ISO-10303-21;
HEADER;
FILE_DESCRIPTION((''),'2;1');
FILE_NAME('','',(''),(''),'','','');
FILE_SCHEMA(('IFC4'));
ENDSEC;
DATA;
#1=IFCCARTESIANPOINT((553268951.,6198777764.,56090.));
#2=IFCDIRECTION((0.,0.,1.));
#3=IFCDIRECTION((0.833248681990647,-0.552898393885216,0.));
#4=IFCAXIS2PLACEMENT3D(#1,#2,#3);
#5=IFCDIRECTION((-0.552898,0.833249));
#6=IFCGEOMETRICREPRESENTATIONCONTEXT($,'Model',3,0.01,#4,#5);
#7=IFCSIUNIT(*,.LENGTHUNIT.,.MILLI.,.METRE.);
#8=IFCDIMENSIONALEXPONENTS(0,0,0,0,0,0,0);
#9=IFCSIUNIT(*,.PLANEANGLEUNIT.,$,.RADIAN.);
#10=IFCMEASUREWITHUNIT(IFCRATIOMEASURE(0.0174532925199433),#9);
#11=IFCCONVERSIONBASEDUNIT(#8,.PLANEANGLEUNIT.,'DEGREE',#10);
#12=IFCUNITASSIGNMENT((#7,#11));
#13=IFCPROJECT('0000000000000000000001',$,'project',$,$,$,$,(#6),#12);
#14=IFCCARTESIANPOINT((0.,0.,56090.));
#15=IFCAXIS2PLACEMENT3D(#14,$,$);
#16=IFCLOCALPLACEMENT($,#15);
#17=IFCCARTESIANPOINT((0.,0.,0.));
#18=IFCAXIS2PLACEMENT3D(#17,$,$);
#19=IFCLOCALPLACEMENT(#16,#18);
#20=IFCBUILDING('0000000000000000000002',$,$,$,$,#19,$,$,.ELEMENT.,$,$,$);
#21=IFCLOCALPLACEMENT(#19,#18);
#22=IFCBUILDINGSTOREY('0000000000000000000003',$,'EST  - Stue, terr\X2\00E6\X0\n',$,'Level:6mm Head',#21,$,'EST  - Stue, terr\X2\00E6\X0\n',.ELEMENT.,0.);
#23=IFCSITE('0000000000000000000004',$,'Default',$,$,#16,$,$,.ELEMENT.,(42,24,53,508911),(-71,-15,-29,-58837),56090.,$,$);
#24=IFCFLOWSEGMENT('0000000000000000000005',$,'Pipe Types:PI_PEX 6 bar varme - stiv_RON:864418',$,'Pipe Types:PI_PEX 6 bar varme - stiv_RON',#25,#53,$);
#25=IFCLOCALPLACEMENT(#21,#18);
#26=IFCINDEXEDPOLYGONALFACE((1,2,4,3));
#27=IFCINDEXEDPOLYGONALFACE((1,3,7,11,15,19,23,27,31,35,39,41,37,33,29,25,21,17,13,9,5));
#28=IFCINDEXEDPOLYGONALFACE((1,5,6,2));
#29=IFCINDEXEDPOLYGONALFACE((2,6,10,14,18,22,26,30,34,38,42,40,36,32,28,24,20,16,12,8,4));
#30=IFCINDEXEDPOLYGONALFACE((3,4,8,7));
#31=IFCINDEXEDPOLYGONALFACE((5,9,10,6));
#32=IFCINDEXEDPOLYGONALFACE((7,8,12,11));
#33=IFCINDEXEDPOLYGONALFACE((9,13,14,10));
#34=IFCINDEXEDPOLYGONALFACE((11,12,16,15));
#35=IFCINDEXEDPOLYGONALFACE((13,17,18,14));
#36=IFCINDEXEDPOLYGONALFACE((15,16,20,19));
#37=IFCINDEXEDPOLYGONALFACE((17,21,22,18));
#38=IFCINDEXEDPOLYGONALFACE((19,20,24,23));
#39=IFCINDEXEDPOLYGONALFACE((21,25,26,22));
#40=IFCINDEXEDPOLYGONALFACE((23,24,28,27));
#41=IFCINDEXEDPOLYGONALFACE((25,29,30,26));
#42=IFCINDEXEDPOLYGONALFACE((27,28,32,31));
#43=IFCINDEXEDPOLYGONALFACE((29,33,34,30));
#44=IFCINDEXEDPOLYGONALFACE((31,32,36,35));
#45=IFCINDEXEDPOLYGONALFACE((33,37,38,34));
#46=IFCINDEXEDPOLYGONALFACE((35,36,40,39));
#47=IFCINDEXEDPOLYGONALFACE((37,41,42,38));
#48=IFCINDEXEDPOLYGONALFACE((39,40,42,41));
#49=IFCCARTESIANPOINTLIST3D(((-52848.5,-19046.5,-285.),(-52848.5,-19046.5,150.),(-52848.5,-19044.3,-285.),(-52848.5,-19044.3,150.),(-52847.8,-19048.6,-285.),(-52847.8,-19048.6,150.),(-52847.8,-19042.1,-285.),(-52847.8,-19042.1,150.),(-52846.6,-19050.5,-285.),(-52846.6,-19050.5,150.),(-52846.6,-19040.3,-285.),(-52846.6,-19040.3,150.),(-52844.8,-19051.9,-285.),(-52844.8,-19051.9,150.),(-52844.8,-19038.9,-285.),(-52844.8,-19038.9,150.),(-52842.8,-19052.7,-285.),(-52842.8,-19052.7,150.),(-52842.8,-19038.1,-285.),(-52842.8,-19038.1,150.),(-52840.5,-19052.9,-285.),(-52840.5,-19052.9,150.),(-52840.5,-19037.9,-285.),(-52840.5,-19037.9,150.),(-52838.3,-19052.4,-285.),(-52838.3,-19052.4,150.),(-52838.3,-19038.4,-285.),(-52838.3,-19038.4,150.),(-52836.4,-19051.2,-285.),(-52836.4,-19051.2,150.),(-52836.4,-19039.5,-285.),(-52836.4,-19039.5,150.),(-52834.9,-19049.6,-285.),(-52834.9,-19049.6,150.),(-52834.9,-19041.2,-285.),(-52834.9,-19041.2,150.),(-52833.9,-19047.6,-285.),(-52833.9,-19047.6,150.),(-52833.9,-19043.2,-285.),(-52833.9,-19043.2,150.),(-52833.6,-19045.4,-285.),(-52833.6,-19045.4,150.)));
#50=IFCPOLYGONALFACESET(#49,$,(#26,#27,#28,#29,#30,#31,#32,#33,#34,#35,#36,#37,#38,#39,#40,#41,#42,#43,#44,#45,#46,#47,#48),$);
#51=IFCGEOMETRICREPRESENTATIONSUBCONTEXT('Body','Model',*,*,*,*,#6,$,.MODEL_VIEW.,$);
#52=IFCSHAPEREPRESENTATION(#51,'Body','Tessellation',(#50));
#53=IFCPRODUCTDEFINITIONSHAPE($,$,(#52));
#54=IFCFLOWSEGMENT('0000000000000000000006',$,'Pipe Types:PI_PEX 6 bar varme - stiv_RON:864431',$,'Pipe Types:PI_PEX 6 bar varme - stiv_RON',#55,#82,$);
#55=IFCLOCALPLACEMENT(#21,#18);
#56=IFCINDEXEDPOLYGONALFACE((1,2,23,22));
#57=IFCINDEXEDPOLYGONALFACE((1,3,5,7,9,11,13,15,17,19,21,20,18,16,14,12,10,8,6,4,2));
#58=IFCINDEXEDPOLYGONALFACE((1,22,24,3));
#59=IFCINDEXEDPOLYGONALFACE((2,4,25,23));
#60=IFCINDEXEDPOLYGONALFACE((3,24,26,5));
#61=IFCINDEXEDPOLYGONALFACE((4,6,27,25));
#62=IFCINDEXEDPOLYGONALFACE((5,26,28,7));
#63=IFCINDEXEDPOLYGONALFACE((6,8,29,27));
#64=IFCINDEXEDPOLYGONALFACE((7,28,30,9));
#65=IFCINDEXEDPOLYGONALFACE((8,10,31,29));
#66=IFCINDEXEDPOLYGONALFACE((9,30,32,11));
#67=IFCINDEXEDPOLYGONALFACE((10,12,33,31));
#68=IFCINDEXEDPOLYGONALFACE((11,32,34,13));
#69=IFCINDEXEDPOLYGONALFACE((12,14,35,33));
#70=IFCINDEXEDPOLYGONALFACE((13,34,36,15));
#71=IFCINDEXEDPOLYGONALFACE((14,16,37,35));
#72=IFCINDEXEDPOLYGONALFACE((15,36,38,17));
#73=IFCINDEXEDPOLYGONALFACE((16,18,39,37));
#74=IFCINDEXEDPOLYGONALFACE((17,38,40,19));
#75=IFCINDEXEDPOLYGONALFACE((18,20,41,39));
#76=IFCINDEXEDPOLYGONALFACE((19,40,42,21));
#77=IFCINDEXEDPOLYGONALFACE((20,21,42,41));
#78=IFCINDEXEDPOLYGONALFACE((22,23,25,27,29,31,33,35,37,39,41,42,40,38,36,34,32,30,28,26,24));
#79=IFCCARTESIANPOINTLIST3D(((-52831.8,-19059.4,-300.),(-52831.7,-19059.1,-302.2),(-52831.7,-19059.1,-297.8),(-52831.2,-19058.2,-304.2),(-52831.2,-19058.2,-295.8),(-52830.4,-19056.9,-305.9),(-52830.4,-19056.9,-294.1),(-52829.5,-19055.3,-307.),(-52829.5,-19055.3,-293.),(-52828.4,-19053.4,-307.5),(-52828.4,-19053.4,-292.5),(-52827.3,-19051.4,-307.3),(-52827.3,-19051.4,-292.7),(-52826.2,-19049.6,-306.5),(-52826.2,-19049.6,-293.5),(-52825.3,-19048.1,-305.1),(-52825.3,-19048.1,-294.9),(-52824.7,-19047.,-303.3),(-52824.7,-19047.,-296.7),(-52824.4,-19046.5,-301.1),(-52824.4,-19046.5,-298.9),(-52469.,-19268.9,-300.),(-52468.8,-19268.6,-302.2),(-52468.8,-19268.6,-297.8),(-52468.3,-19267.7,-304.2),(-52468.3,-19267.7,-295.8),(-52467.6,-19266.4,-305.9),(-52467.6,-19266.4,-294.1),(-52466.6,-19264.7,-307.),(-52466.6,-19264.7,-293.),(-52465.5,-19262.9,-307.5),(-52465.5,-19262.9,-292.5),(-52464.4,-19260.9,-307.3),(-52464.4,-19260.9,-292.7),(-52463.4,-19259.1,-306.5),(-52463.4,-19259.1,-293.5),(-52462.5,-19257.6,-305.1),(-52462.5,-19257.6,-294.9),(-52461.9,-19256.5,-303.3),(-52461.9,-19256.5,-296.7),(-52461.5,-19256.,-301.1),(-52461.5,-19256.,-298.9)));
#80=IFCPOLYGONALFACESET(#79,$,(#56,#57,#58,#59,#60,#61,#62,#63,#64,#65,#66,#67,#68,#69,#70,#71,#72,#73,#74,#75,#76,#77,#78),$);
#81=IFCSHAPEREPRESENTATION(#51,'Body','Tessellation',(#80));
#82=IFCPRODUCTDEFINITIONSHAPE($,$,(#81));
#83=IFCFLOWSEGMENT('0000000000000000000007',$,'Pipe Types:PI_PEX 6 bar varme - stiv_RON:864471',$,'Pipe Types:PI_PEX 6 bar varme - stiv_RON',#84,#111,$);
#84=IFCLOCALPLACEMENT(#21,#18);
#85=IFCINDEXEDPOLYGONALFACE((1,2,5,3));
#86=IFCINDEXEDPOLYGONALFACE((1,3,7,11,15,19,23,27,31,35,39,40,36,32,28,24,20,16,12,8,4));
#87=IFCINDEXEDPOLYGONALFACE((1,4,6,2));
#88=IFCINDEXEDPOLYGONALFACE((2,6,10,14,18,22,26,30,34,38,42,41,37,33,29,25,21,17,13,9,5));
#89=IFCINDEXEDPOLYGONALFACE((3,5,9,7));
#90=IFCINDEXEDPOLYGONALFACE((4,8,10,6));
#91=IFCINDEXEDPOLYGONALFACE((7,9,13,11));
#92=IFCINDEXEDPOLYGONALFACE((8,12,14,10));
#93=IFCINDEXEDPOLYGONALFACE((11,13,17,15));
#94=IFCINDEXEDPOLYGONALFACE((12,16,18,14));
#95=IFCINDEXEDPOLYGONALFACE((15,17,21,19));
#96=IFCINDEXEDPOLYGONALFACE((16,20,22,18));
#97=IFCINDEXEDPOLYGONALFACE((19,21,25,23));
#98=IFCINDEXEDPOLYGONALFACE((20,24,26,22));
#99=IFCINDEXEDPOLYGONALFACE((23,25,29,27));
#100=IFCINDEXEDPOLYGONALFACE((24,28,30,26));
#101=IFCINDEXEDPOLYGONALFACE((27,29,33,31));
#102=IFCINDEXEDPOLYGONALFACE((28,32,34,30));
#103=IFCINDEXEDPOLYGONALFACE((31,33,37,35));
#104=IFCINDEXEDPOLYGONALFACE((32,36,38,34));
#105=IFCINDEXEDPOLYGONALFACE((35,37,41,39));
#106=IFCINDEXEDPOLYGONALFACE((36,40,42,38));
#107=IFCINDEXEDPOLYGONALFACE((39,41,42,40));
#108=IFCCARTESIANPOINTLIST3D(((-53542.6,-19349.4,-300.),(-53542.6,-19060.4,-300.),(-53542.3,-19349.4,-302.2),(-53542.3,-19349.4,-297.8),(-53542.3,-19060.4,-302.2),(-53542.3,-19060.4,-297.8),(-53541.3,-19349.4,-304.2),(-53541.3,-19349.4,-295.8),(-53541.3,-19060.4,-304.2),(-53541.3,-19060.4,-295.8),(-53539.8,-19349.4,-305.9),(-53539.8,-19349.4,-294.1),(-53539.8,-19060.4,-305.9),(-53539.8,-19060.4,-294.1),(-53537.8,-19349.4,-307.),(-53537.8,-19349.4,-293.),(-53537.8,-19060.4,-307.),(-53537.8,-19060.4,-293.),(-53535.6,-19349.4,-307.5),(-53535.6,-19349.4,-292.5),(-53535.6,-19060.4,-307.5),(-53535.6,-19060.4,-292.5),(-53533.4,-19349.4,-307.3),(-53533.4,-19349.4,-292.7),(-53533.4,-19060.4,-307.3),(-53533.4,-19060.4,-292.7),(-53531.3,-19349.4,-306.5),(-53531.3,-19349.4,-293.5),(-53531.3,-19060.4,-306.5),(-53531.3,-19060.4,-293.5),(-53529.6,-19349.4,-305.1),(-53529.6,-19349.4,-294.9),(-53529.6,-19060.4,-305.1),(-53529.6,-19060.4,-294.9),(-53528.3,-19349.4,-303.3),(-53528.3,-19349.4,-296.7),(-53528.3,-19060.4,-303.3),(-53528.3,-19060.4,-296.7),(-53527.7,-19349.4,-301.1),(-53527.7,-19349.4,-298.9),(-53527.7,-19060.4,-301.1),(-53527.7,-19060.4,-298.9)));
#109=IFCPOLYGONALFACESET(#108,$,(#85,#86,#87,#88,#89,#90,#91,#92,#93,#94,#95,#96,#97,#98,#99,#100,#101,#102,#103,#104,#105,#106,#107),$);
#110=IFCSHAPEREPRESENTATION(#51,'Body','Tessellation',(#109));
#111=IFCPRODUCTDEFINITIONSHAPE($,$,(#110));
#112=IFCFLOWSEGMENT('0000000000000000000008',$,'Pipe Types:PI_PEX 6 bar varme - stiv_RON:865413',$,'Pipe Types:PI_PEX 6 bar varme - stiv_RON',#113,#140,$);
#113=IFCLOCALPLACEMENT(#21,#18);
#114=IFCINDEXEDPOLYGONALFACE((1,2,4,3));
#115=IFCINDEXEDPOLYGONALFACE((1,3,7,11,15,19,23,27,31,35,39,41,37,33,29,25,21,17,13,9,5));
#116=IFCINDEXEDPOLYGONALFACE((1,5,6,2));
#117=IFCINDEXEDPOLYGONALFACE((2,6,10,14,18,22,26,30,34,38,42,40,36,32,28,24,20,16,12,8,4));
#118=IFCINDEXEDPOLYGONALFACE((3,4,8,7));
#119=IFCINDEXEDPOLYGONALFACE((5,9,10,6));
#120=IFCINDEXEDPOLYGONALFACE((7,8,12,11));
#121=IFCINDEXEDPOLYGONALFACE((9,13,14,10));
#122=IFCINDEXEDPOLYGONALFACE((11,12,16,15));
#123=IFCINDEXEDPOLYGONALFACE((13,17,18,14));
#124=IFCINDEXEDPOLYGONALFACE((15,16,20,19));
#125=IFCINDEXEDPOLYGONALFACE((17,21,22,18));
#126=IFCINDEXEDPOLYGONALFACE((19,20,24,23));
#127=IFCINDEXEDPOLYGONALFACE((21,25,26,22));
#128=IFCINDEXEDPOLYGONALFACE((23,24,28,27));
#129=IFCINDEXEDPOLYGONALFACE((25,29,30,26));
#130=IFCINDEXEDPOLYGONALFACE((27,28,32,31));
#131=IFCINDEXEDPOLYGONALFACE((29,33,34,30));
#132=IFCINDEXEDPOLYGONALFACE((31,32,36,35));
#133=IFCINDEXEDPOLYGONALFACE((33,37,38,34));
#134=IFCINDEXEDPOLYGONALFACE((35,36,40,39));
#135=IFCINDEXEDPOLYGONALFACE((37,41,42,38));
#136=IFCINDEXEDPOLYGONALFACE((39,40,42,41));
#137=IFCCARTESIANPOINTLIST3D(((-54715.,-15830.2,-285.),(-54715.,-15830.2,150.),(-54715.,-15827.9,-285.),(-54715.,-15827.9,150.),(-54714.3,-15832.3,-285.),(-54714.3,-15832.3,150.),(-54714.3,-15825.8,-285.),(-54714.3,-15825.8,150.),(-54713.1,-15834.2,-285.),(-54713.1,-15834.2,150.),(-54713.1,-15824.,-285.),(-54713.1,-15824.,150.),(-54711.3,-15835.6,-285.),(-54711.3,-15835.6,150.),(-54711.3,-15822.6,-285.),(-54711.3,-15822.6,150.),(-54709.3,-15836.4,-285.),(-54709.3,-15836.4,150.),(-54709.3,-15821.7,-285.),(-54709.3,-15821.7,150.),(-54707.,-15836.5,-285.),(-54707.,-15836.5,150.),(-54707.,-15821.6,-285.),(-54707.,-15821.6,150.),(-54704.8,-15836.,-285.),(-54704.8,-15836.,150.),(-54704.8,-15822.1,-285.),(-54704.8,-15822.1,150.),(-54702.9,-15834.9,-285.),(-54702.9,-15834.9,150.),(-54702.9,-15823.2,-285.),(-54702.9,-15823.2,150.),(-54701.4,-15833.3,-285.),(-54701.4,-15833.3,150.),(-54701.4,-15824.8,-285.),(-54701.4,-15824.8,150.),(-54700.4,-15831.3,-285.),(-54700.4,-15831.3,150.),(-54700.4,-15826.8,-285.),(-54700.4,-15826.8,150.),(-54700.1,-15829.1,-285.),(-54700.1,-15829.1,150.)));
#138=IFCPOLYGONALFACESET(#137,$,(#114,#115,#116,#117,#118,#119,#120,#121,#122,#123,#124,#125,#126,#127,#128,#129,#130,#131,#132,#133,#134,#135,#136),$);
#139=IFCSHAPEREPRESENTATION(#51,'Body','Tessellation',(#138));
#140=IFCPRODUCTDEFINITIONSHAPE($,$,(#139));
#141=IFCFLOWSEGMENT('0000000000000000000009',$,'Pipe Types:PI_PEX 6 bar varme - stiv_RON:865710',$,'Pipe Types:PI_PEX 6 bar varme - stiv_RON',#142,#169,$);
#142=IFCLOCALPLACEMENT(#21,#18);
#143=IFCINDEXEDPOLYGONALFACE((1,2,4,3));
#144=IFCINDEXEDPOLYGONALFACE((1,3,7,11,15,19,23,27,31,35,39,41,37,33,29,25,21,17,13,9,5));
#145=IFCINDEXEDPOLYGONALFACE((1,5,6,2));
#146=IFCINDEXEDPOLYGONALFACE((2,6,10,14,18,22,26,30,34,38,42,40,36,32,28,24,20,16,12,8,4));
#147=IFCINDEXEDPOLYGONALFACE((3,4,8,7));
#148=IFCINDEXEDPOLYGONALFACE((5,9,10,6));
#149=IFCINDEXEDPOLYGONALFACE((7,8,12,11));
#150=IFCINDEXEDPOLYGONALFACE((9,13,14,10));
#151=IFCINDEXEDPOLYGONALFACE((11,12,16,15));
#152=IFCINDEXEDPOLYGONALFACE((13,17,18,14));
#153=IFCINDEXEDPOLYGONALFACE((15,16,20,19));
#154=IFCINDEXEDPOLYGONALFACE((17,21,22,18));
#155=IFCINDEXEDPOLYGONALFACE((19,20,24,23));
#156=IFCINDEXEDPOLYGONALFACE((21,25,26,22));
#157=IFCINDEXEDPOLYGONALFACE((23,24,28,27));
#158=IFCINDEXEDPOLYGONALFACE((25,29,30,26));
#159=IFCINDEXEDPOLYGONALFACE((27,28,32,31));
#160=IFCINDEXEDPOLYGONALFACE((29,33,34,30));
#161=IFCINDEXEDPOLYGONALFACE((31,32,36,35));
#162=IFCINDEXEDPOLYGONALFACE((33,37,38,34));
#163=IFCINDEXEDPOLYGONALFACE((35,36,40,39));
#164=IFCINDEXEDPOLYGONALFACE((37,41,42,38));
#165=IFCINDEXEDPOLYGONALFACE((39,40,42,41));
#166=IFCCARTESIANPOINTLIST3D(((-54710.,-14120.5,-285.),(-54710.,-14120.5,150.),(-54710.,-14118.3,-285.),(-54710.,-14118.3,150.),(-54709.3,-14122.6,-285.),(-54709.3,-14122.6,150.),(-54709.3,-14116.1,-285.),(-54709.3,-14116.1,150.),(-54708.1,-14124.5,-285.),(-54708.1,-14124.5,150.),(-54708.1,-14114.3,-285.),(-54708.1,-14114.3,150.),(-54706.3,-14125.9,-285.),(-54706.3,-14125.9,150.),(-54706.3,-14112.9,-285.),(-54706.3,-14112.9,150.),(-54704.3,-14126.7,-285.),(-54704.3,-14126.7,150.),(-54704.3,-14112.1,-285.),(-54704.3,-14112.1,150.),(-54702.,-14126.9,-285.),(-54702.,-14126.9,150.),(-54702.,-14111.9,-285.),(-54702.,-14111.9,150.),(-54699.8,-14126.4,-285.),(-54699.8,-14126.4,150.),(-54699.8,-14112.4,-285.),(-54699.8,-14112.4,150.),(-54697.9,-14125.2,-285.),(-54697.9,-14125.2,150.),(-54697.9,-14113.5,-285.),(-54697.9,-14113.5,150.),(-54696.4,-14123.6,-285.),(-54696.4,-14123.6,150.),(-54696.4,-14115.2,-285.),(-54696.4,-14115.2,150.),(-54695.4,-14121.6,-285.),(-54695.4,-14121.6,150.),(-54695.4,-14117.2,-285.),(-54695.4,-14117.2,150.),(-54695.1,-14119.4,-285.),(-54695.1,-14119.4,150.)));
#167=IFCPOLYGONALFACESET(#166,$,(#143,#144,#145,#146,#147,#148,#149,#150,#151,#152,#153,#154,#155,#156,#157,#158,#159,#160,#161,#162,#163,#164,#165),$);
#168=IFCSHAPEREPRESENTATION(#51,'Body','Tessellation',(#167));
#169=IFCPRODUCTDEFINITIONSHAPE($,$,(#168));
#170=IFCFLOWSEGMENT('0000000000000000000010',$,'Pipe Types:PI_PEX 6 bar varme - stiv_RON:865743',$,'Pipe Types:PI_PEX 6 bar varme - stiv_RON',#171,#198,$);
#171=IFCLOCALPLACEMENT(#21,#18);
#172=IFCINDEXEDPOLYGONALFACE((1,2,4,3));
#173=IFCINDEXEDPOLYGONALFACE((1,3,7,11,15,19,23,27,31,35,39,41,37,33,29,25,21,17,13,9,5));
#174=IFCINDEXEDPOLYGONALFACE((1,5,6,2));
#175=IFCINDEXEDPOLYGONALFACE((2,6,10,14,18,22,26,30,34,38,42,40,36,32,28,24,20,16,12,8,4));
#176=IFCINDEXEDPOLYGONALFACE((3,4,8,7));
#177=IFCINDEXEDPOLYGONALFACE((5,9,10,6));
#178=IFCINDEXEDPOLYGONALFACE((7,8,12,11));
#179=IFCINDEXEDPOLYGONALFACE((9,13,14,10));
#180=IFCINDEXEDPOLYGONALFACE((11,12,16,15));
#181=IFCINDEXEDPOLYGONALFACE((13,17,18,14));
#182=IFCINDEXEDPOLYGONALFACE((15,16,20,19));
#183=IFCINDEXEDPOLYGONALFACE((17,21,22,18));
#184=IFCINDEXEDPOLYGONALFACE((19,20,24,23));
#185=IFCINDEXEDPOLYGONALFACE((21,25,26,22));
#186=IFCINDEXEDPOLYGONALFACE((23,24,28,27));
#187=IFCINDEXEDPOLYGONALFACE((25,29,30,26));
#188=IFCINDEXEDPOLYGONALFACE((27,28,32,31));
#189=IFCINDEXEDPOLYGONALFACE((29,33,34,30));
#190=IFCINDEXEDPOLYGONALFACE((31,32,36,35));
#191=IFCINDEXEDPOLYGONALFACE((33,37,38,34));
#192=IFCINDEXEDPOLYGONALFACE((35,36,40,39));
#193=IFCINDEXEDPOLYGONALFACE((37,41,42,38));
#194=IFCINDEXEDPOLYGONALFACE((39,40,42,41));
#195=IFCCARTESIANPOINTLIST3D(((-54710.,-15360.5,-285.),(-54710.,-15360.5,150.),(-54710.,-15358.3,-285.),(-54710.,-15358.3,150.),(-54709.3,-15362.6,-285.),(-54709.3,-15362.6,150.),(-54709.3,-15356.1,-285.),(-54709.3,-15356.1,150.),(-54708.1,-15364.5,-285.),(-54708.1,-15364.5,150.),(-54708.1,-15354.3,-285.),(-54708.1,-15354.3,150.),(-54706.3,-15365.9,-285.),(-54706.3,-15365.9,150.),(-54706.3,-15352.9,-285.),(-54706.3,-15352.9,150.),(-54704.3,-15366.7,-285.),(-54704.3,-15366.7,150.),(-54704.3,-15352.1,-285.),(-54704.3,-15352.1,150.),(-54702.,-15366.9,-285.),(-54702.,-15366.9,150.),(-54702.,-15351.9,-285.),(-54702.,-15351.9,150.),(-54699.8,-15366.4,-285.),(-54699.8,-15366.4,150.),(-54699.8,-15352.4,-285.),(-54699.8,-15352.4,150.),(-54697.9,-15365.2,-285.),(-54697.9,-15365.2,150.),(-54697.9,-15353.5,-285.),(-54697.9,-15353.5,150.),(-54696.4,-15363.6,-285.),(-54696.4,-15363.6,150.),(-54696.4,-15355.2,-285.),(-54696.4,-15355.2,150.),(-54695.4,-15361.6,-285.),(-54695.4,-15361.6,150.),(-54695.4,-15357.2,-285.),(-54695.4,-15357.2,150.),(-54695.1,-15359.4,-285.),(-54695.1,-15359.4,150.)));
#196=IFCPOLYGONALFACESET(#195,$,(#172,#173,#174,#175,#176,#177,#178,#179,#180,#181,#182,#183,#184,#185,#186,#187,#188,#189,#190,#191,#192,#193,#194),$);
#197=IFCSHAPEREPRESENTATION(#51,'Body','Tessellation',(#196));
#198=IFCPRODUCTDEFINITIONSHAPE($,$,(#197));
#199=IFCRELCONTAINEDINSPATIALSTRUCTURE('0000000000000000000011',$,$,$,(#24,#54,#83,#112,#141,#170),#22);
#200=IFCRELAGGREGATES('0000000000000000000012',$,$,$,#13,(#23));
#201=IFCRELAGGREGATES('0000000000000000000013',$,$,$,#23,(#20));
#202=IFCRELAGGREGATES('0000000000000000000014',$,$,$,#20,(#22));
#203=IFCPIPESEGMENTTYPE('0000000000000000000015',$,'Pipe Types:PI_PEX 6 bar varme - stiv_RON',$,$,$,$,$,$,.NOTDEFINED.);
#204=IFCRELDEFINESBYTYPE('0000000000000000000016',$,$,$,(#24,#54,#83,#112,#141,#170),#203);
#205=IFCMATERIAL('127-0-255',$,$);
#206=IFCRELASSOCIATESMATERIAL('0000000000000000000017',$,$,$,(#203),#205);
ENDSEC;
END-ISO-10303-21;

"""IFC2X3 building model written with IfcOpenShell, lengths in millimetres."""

from ifc_helpers import new_model, entity, si_unit, converted_unit, direction, frame, frame_2d, origin, origin_2d_with_axis, place, context, subcontext, project, spatial, circle, extrude, material, type_object, element, save


model = new_model("IFC2X3")

# Units and contexts
model_context = context("Model", 3, precision=0.01, world=frame((553268951.0, 6198777764.0, 56090.0), z_axis=(0.0, 0.0, 1.0), x_axis=(0.833248681990647, -0.552898393885216, 0.0)), true_north=direction((-0.552898, 0.833249)))
body_context = subcontext(model_context, "Body", "Model", "MODEL_VIEW")
ifc_project = project(units=[si_unit("LENGTHUNIT", "METRE", prefix="MILLI"), converted_unit("PLANEANGLEUNIT", "DEGREE", entity("IfcRatioMeasure", 0.0174532925199433), si_unit("PLANEANGLEUNIT", "RADIAN"), dimensions=[0, 0, 0, 0, 0, 0, 0])], contexts=[model_context])

# Site, building, storey
site_placement = place(None, frame((0.0, 0.0, 56090.0)))
site = spatial("IfcSite", under=ifc_project, at=site_placement, Name="Default", CompositionType="ELEMENT", RefLatitude=(42, 24, 53, 508911), RefLongitude=(-71, -15, -29, -58837), RefElevation=56090.0)
building_placement = place(site_placement, origin())
building = spatial("IfcBuilding", under=site, at=building_placement, CompositionType="ELEMENT")
storey_placement = place(building_placement, frame((0.0, 0.0, 0.0)))
storey = spatial("IfcBuildingStorey", under=building, at=storey_placement, Name="EST  - Stue, terræn", ObjectType="Level:6mm Head", LongName="EST  - Stue, terræn", CompositionType="ELEMENT", Elevation=0.0)

# Flow segments
ifc_material = material(Name="127-0-255")
pipe_segment_type = type_object("IfcPipeSegmentType", Name="Pipe Types:PI_PEX 6 bar varme - stiv_RON", PredefinedType="NOTDEFINED", material=ifc_material)
flow_segment_1_placement = place(storey_placement, origin())
element("IfcFlowSegment", 1, at=flow_segment_1_placement, inside=storey, type_object=pipe_segment_type, Name="Pipe Types:PI_PEX 6 bar varme - stiv_RON:864418", ObjectType="Pipe Types:PI_PEX 6 bar varme - stiv_RON", context=body_context, shape_type="SweptSolid", body=[
    extrude(circle(Radius=7.5, at=origin_2d_with_axis()), frame((-52841.1, -19045.4, -285.0)), (0.0, 0.0, 1.0), 435.0),
])
flow_segment_2_placement = place(storey_placement, origin())
element("IfcFlowSegment", 2, at=flow_segment_2_placement, inside=storey, type_object=pipe_segment_type, Name="Pipe Types:PI_PEX 6 bar varme - stiv_RON:864431", ObjectType="Pipe Types:PI_PEX 6 bar varme - stiv_RON", context=body_context, shape_type="SweptSolid", body=[
    extrude(circle(Radius=7.5, at=frame_2d((0.0, 0.0), x_axis=(1.0, 0.0))), frame((-52465.3, -19262.4, -300.0), z_axis=(-0.866025, 0.5, 0.0), x_axis=(-0.5, -0.866025, 0.0)), (0.0, 0.0, 1.0), 419.0),
])
flow_segment_3_placement = place(storey_placement, origin())
element("IfcFlowSegment", 3, at=flow_segment_3_placement, inside=storey, type_object=pipe_segment_type, Name="Pipe Types:PI_PEX 6 bar varme - stiv_RON:864471", ObjectType="Pipe Types:PI_PEX 6 bar varme - stiv_RON", context=body_context, shape_type="SweptSolid", body=[
    extrude(circle(Radius=7.5, at=frame_2d((0.0, 0.0), x_axis=(1.0, 0.0))), frame((-53535.1, -19349.4, -300.0), z_axis=(0.0, 1.0, 0.0), x_axis=(-1.0, 0.0, 0.0)), (0.0, 0.0, 1.0), 289.0),
])
flow_segment_4_placement = place(storey_placement, origin())
element("IfcFlowSegment", 4, at=flow_segment_4_placement, inside=storey, type_object=pipe_segment_type, Name="Pipe Types:PI_PEX 6 bar varme - stiv_RON:865413", ObjectType="Pipe Types:PI_PEX 6 bar varme - stiv_RON", context=body_context, shape_type="SweptSolid", body=[
    extrude(circle(Radius=7.5, at=frame_2d((0.0, 0.0), x_axis=(1.0, 0.0))), frame((-54707.6, -15829.1, -285.0)), (0.0, 0.0, 1.0), 435.0),
])
flow_segment_5_placement = place(storey_placement, origin())
element("IfcFlowSegment", 5, at=flow_segment_5_placement, inside=storey, type_object=pipe_segment_type, Name="Pipe Types:PI_PEX 6 bar varme - stiv_RON:865710", ObjectType="Pipe Types:PI_PEX 6 bar varme - stiv_RON", context=body_context, shape_type="SweptSolid", body=[
    extrude(circle(Radius=7.5, at=frame_2d((0.0, 0.0), x_axis=(1.0, 0.0))), frame((-54702.6, -14119.4, -285.0)), (0.0, 0.0, 1.0), 435.0),
])
flow_segment_6_placement = place(storey_placement, origin())
element("IfcFlowSegment", 6, at=flow_segment_6_placement, inside=storey, type_object=pipe_segment_type, Name="Pipe Types:PI_PEX 6 bar varme - stiv_RON:865743", ObjectType="Pipe Types:PI_PEX 6 bar varme - stiv_RON", context=body_context, shape_type="SweptSolid", body=[
    extrude(circle(Radius=7.5, at=origin_2d_with_axis()), frame((-54702.6, -15359.4, -285.0)), (0.0, 0.0, 1.0), 435.0),
])

save(model, "model.ifc")
